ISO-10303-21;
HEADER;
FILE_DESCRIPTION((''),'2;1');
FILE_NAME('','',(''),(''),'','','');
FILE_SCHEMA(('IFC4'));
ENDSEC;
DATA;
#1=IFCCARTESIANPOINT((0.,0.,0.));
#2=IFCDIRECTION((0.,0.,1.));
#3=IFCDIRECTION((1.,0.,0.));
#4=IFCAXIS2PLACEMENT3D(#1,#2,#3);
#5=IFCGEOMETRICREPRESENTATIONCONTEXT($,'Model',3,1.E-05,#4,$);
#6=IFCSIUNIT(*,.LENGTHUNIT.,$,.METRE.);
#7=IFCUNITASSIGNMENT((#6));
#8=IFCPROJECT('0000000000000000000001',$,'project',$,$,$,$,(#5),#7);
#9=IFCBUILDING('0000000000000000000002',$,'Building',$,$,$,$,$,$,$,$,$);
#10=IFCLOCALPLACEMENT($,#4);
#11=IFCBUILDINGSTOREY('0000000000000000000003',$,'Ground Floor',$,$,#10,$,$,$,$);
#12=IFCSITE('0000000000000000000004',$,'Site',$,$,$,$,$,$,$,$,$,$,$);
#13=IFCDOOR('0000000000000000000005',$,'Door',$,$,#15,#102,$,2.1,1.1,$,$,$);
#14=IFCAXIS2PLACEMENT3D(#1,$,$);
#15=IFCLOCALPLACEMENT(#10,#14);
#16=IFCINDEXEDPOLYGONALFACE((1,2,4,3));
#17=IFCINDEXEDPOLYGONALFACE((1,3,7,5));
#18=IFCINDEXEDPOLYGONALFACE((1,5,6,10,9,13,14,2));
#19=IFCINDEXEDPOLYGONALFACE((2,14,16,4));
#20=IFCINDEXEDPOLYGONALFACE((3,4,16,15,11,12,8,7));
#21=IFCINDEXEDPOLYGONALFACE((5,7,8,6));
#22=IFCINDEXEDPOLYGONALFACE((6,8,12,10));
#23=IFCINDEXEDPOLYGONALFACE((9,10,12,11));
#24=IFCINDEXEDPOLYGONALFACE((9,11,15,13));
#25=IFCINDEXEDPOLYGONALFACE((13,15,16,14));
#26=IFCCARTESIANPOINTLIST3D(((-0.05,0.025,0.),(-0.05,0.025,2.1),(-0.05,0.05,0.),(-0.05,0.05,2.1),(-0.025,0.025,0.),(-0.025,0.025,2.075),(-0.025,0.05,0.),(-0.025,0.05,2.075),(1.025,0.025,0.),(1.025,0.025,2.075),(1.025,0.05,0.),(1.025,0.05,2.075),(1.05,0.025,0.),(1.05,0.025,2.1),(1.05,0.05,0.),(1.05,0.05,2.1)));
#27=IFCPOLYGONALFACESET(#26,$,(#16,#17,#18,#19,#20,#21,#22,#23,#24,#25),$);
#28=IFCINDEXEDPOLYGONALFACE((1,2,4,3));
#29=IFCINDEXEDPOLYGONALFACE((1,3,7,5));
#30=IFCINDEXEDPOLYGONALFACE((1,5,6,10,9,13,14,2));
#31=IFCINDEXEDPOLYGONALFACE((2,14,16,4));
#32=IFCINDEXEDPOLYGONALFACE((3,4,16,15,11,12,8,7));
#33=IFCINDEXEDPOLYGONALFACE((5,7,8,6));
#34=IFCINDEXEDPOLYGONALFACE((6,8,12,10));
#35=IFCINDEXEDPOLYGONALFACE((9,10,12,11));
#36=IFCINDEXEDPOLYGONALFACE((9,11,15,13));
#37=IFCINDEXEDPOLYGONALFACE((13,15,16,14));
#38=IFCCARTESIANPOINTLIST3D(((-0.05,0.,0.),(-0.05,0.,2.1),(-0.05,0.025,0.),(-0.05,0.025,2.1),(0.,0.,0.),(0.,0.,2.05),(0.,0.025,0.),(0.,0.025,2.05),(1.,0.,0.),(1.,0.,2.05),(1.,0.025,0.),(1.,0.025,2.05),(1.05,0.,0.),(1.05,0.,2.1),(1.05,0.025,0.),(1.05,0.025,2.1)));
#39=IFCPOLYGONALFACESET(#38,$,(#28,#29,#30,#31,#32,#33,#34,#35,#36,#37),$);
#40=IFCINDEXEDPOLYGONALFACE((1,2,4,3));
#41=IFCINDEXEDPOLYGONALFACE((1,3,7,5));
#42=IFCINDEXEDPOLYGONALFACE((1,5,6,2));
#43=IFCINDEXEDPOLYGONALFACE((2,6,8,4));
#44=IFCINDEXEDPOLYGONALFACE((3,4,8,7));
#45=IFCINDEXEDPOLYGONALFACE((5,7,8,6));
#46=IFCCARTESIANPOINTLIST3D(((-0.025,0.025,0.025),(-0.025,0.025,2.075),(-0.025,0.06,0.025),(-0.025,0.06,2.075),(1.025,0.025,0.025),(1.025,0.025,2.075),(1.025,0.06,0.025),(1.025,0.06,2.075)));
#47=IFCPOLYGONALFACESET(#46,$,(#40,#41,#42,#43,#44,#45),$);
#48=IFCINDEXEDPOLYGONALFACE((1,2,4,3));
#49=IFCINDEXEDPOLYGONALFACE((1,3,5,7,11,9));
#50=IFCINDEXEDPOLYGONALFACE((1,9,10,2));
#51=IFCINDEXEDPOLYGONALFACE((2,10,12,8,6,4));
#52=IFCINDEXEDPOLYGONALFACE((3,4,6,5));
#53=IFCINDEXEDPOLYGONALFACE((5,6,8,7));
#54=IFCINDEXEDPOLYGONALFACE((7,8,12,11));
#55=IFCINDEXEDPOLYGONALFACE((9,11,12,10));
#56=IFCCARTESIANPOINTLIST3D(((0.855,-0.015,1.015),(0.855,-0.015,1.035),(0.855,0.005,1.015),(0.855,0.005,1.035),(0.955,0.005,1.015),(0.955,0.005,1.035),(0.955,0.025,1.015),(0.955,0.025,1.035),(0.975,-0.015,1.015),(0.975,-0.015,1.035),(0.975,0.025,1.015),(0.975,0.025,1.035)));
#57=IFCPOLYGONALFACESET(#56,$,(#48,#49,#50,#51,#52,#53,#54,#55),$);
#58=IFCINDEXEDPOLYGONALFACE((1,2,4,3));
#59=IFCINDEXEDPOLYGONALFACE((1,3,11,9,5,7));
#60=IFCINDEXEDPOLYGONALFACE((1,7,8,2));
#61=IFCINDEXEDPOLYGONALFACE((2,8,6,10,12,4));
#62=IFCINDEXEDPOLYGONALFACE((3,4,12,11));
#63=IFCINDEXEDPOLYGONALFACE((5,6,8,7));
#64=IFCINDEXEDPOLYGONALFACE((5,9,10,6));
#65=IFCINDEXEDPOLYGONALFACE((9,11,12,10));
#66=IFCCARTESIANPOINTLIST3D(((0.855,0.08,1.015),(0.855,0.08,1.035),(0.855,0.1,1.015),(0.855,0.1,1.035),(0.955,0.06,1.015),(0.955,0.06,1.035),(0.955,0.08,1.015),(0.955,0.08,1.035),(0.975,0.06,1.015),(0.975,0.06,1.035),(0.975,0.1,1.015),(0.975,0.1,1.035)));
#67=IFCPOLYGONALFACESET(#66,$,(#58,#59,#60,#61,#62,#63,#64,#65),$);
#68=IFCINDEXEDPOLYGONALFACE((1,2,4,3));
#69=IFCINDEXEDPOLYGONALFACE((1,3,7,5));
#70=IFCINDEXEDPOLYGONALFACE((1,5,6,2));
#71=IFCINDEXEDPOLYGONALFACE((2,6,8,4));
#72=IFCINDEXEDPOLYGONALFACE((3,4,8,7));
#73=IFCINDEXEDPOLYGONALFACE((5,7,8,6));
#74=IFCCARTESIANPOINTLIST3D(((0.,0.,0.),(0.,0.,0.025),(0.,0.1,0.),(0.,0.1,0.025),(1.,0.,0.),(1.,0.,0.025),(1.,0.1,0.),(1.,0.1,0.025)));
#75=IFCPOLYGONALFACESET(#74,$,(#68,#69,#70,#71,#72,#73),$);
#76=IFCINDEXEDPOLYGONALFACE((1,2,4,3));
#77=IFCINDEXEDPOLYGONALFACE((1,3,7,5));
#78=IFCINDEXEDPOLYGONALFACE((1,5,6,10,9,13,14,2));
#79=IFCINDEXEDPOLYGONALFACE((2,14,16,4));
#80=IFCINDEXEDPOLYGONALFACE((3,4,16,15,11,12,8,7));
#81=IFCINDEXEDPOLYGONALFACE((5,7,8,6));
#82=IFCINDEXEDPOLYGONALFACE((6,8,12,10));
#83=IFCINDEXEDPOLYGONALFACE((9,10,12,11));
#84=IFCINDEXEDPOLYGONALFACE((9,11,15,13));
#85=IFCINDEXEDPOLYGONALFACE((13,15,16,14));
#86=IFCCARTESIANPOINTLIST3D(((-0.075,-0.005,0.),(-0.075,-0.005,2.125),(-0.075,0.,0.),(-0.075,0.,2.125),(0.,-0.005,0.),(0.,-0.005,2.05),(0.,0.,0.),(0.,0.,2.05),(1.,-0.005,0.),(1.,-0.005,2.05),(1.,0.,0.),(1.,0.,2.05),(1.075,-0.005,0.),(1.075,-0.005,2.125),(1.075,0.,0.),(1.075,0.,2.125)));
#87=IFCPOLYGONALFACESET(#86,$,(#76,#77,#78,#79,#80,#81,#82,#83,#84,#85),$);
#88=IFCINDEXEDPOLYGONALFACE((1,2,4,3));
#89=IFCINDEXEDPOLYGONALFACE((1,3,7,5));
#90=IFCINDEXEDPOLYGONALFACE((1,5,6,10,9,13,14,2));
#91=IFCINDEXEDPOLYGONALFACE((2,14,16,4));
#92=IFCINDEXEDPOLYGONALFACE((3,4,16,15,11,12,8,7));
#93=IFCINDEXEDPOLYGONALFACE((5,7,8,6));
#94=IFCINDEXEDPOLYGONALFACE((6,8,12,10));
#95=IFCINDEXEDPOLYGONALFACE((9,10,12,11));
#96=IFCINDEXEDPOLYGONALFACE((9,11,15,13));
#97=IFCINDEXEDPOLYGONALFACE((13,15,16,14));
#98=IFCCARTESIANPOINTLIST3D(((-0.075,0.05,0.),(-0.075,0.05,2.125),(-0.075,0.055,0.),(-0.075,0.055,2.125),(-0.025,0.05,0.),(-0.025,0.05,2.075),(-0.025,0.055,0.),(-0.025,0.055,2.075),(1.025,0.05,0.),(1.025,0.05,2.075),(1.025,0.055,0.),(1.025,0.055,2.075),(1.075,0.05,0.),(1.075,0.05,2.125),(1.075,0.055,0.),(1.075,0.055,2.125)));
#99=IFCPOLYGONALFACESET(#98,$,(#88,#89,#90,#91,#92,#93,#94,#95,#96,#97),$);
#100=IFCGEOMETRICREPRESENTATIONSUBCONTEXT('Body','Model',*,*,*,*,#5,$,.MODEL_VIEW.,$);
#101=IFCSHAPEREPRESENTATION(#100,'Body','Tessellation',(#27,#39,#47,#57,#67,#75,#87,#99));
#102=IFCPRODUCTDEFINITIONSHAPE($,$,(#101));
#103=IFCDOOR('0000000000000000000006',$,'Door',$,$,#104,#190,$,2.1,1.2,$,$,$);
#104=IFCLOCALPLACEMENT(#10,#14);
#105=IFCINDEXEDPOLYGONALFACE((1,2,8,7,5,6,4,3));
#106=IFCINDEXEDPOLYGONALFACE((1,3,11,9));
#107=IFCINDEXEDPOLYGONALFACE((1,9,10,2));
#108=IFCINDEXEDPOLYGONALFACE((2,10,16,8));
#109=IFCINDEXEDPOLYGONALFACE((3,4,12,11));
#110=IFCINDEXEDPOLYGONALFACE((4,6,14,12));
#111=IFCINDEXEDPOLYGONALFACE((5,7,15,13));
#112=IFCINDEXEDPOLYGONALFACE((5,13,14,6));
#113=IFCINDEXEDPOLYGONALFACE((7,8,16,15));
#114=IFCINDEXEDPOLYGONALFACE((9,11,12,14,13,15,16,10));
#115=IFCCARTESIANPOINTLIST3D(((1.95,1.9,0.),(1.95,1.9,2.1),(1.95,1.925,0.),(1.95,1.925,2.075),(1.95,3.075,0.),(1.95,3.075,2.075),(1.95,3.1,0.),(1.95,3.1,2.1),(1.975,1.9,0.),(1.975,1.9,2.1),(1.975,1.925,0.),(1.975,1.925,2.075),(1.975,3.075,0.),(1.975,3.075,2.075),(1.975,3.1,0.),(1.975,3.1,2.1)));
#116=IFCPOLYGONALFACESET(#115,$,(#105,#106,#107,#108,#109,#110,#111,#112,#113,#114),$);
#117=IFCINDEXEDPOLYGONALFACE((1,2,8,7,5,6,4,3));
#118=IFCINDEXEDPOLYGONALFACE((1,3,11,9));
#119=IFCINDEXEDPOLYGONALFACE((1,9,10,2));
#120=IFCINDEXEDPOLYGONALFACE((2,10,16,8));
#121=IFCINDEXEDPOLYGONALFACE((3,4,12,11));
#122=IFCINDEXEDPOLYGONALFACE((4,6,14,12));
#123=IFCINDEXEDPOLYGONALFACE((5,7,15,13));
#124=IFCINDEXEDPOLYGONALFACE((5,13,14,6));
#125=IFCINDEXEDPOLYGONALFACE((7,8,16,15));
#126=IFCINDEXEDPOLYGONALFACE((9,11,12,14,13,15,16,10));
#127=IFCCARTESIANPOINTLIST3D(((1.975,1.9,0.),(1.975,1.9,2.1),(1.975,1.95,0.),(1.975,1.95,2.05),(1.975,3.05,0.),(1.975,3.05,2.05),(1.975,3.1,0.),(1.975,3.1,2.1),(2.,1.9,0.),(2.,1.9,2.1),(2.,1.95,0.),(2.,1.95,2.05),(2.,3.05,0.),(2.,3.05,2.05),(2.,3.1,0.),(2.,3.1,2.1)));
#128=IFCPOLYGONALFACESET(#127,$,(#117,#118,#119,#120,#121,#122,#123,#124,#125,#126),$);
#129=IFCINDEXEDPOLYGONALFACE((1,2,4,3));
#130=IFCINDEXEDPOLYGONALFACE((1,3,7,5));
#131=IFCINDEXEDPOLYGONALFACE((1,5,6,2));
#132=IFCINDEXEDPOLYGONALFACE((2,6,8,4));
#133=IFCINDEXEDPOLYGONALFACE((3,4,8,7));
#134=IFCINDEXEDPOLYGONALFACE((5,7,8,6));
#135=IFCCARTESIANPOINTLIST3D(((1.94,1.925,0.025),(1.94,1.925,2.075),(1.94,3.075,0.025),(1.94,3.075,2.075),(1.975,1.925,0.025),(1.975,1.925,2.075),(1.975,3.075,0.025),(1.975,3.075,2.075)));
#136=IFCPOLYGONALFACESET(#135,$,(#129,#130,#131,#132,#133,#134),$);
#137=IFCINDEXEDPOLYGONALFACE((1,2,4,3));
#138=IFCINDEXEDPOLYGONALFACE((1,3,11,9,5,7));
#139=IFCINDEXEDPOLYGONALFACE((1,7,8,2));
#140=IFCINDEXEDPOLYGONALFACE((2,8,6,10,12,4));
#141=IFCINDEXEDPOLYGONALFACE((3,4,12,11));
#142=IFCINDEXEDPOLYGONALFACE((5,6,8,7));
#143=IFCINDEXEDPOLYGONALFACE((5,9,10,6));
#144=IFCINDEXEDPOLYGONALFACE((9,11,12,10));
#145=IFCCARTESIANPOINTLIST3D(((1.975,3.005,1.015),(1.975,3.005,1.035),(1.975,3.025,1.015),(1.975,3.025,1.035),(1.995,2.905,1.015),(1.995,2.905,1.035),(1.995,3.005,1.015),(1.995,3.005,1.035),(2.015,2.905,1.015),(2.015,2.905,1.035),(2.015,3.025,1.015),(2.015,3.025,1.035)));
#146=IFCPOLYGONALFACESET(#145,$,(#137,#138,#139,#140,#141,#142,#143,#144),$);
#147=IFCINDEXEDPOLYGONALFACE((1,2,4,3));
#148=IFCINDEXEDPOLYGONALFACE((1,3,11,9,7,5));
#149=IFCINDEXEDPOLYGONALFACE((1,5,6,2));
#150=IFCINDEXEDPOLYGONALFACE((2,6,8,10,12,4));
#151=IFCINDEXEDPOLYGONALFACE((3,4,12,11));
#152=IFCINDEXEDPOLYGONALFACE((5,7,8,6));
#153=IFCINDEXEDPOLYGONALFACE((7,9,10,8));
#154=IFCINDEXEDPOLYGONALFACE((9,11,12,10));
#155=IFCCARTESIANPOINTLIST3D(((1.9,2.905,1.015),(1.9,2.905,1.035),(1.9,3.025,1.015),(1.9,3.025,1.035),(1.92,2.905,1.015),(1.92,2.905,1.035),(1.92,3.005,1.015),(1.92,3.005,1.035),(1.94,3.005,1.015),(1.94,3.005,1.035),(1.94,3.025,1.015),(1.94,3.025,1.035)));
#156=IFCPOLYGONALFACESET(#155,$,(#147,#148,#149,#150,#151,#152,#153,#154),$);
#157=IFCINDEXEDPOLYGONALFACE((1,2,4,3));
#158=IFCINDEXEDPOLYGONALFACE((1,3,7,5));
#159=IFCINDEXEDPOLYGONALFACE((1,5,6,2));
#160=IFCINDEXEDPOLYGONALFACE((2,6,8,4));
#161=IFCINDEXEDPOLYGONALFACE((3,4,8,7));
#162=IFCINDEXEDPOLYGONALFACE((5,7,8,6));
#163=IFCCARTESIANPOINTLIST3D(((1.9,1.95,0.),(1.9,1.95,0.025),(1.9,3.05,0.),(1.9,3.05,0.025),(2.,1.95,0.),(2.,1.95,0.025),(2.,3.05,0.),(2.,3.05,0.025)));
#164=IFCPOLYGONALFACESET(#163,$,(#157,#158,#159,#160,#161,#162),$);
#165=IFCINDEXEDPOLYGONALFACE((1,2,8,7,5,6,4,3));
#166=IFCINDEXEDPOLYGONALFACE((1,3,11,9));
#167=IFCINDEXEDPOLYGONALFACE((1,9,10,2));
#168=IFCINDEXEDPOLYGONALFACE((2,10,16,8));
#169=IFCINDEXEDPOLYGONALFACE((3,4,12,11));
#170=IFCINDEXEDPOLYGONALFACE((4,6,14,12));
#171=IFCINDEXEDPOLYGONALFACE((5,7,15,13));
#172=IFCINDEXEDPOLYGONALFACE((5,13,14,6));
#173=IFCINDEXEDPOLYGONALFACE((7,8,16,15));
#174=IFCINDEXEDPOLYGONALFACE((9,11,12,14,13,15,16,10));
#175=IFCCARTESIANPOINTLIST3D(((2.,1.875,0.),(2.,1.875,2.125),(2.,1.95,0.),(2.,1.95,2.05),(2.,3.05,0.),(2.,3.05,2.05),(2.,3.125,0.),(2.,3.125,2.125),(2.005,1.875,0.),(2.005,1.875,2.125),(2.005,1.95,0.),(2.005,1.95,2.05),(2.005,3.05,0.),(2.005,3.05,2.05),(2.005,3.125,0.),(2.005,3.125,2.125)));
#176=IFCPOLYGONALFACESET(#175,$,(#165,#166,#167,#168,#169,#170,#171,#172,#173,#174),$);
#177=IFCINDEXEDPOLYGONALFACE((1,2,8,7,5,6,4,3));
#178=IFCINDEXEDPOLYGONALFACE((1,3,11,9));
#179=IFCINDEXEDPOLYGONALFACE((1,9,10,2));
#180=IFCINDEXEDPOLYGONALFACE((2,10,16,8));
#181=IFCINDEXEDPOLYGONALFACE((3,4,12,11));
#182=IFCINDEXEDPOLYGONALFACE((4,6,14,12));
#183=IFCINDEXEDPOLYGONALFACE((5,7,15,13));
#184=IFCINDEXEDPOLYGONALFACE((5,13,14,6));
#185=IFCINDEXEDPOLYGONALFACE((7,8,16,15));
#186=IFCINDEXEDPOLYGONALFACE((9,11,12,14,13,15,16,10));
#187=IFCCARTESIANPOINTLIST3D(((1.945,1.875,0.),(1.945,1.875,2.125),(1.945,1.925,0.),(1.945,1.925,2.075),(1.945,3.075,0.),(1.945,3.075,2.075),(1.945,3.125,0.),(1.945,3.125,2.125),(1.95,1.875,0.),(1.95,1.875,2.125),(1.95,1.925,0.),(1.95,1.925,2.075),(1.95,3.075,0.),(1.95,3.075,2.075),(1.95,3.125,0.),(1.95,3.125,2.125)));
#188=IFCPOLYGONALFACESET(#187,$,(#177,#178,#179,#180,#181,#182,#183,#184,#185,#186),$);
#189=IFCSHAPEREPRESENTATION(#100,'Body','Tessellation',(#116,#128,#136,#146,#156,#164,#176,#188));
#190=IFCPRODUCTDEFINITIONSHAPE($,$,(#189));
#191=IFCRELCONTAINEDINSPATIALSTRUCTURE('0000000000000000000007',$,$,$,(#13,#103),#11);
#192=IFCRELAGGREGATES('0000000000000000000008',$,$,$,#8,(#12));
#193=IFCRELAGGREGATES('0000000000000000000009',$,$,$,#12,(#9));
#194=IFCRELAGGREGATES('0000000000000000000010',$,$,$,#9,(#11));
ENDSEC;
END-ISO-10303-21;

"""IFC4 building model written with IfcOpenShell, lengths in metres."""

from ifc_helpers import new_model, si_unit, frame, origin_with_axes, place, context, subcontext, project, spatial, line, indexed_curve, outline, extrude, element, save


model = new_model("IFC4")

# Units and contexts
model_context = context("Model", 3, precision=1e-05, world=origin_with_axes())
body_context = subcontext(model_context, "Body", "Model", "MODEL_VIEW")
ifc_project = project(units=[si_unit("LENGTHUNIT", "METRE")], contexts=[model_context])

# Site, building, storey
site = spatial("IfcSite", under=ifc_project, Name="Site")
building = spatial("IfcBuilding", under=site, Name="Building")
storey_placement = place(None, origin_with_axes())
storey = spatial("IfcBuildingStorey", under=building, at=storey_placement, Name="Ground Floor")

# Doors
door_1_placement = place(storey_placement, frame((-0.05, 0.0, 0.0), z_axis=(0.0, 0.0, 1.0), x_axis=(1.0, 0.0, 0.0)))
element("IfcDoor", 1, at=door_1_placement, inside=storey, Name="Door", OverallHeight=2.1, OverallWidth=1.1, context=body_context, shape_type="SweptSolid", body=[
    extrude(outline(indexed_curve([(0.0, 0.0), (0.0, 2.1), (1.1, 2.1), (1.1, 0.0), (1.075, 0.0), (1.075, 2.075), (0.025, 2.075), (0.025, 0.0)], segments=[line(1, 2, 3, 4, 5, 6, 7, 8, 1)])), frame((0.0, 0.025, 0.0), z_axis=(0.0, -1.0, 0.0), x_axis=(1.0, 0.0, 0.0)), (0.0, 0.0, -1.0), 0.025),
    extrude(outline(indexed_curve([(0.0, 0.0), (0.0, 2.1), (1.1, 2.1), (1.1, 0.0), (1.05, 0.0), (1.05, 2.05), (0.05, 2.05), (0.05, 0.0)], segments=[line(1, 2, 3, 4, 5, 6, 7, 8, 1)])), frame((0.0, 0.0, 0.0), z_axis=(0.0, -1.0, 0.0), x_axis=(1.0, 0.0, 0.0)), (0.0, 0.0, -1.0), 0.025),
    extrude(outline(indexed_curve([(0.0, 0.0), (1.05, 0.0), (1.05, 0.035), (0.0, 0.035)], segments=[line(1, 2, 3, 4, 1)])), frame((0.025, 0.025, 0.025), z_axis=(0.0, 0.0, 1.0), x_axis=(1.0, 0.0, 0.0)), (0.0, 0.0, 1.0), 2.05),
    extrude(outline(indexed_curve([(0.0, 0.0), (0.0, -0.04), (-0.12, -0.04), (-0.12, -0.02), (-0.02, -0.02), (-0.02, 0.0)], segments=[line(1, 2, 3, 4, 5, 6, 1)])), frame((1.025, 0.025, 1.015), z_axis=(0.0, 0.0, 1.0), x_axis=(1.0, 0.0, 0.0)), (0.0, 0.0, 1.0), 0.02),
    extrude(outline(indexed_curve([(0.0, 0.0), (0.0, 0.04), (-0.12, 0.04), (-0.12, 0.02), (-0.02, 0.02), (-0.02, 0.0)], segments=[line(1, 2, 3, 4, 5, 6, 1)])), frame((1.025, 0.06, 1.015), z_axis=(0.0, 0.0, 1.0), x_axis=(1.0, 0.0, 0.0)), (0.0, 0.0, 1.0), 0.02),
    extrude(outline(indexed_curve([(0.0, 0.0), (1.0, 0.0), (1.0, 0.1), (0.0, 0.1)], segments=[line(1, 2, 3, 4, 1)])), frame((0.05, 0.0, 0.0), z_axis=(0.0, 0.0, 1.0), x_axis=(1.0, 0.0, 0.0)), (0.0, 0.0, 1.0), 0.025),
    extrude(outline(indexed_curve([(0.0, 0.0), (0.0, 2.125), (1.15, 2.125), (1.15, 0.0), (1.075, 0.0), (1.075, 2.05), (0.075, 2.05), (0.075, 0.0)], segments=[line(1, 2, 3, 4, 5, 6, 7, 8, 1)])), frame((-0.025, -0.005, 0.0), z_axis=(0.0, -1.0, 0.0), x_axis=(1.0, 0.0, 0.0)), (0.0, 0.0, -1.0), 0.005),
    extrude(outline(indexed_curve([(0.0, 0.0), (0.0, 2.125), (1.15, 2.125), (1.15, 0.0), (1.1, 0.0), (1.1, 2.075), (0.05, 2.075), (0.05, 0.0)], segments=[line(1, 2, 3, 4, 5, 6, 7, 8, 1)])), frame((-0.025, 0.05, 0.0), z_axis=(0.0, -1.0, 0.0), x_axis=(1.0, 0.0, 0.0)), (0.0, 0.0, -1.0), 0.005),
])
door_2_placement = place(storey_placement, frame((2.0, 1.9, 0.0), z_axis=(0.0, 0.0, 1.0), x_axis=(0.0, 1.0, 0.0)))
element("IfcDoor", 2, at=door_2_placement, inside=storey, Name="Door", OverallHeight=2.1, OverallWidth=1.2, context=body_context, shape_type="SweptSolid", body=[
    extrude(outline(indexed_curve([(0.0, 0.0), (0.0, 2.1), (1.2, 2.1), (1.2, 0.0), (1.175, 0.0), (1.175, 2.075), (0.025, 2.075), (0.025, 0.0)], segments=[line(1, 2, 3, 4, 5, 6, 7, 8, 1)])), frame((0.0, 0.025, 0.0), z_axis=(0.0, -1.0, 0.0), x_axis=(1.0, 0.0, 0.0)), (0.0, 0.0, -1.0), 0.025),
    extrude(outline(indexed_curve([(0.0, 0.0), (0.0, 2.1), (1.2, 2.1), (1.2, 0.0), (1.15, 0.0), (1.15, 2.05), (0.05, 2.05), (0.05, 0.0)], segments=[line(1, 2, 3, 4, 5, 6, 7, 8, 1)])), frame((0.0, 0.0, 0.0), z_axis=(0.0, -1.0, 0.0), x_axis=(1.0, 0.0, 0.0)), (0.0, 0.0, -1.0), 0.025),
    extrude(outline(indexed_curve([(0.0, 0.0), (1.15, 0.0), (1.15, 0.035), (0.0, 0.035)], segments=[line(1, 2, 3, 4, 1)])), frame((0.025, 0.025, 0.025), z_axis=(0.0, 0.0, 1.0), x_axis=(1.0, 0.0, 0.0)), (0.0, 0.0, 1.0), 2.05),
    extrude(outline(indexed_curve([(0.0, 0.0), (0.0, -0.04), (-0.12, -0.04), (-0.12, -0.02), (-0.02, -0.02), (-0.02, 0.0)], segments=[line(1, 2, 3, 4, 5, 6, 1)])), frame((1.125, 0.025, 1.015), z_axis=(0.0, 0.0, 1.0), x_axis=(1.0, 0.0, 0.0)), (0.0, 0.0, 1.0), 0.02),
    extrude(outline(indexed_curve([(0.0, 0.0), (0.0, 0.04), (-0.12, 0.04), (-0.12, 0.02), (-0.02, 0.02), (-0.02, 0.0)], segments=[line(1, 2, 3, 4, 5, 6, 1)])), frame((1.125, 0.06, 1.015), z_axis=(0.0, 0.0, 1.0), x_axis=(1.0, 0.0, 0.0)), (0.0, 0.0, 1.0), 0.02),
    extrude(outline(indexed_curve([(0.0, 0.0), (1.1, 0.0), (1.1, 0.1), (0.0, 0.1)], segments=[line(1, 2, 3, 4, 1)])), frame((0.05, 0.0, 0.0), z_axis=(0.0, 0.0, 1.0), x_axis=(1.0, 0.0, 0.0)), (0.0, 0.0, 1.0), 0.025),
    extrude(outline(indexed_curve([(0.0, 0.0), (0.0, 2.125), (1.25, 2.125), (1.25, 0.0), (1.175, 0.0), (1.175, 2.05), (0.075, 2.05), (0.075, 0.0)], segments=[line(1, 2, 3, 4, 5, 6, 7, 8, 1)])), frame((-0.025, -0.005, 0.0), z_axis=(0.0, -1.0, 0.0), x_axis=(1.0, 0.0, 0.0)), (0.0, 0.0, -1.0), 0.005),
    extrude(outline(indexed_curve([(0.0, 0.0), (0.0, 2.125), (1.25, 2.125), (1.25, 0.0), (1.2, 0.0), (1.2, 2.075), (0.05, 2.075), (0.05, 0.0)], segments=[line(1, 2, 3, 4, 5, 6, 7, 8, 1)])), frame((-0.025, 0.05, 0.0), z_axis=(0.0, -1.0, 0.0), x_axis=(1.0, 0.0, 0.0)), (0.0, 0.0, -1.0), 0.005),
])

save(model, "model.ifc")
